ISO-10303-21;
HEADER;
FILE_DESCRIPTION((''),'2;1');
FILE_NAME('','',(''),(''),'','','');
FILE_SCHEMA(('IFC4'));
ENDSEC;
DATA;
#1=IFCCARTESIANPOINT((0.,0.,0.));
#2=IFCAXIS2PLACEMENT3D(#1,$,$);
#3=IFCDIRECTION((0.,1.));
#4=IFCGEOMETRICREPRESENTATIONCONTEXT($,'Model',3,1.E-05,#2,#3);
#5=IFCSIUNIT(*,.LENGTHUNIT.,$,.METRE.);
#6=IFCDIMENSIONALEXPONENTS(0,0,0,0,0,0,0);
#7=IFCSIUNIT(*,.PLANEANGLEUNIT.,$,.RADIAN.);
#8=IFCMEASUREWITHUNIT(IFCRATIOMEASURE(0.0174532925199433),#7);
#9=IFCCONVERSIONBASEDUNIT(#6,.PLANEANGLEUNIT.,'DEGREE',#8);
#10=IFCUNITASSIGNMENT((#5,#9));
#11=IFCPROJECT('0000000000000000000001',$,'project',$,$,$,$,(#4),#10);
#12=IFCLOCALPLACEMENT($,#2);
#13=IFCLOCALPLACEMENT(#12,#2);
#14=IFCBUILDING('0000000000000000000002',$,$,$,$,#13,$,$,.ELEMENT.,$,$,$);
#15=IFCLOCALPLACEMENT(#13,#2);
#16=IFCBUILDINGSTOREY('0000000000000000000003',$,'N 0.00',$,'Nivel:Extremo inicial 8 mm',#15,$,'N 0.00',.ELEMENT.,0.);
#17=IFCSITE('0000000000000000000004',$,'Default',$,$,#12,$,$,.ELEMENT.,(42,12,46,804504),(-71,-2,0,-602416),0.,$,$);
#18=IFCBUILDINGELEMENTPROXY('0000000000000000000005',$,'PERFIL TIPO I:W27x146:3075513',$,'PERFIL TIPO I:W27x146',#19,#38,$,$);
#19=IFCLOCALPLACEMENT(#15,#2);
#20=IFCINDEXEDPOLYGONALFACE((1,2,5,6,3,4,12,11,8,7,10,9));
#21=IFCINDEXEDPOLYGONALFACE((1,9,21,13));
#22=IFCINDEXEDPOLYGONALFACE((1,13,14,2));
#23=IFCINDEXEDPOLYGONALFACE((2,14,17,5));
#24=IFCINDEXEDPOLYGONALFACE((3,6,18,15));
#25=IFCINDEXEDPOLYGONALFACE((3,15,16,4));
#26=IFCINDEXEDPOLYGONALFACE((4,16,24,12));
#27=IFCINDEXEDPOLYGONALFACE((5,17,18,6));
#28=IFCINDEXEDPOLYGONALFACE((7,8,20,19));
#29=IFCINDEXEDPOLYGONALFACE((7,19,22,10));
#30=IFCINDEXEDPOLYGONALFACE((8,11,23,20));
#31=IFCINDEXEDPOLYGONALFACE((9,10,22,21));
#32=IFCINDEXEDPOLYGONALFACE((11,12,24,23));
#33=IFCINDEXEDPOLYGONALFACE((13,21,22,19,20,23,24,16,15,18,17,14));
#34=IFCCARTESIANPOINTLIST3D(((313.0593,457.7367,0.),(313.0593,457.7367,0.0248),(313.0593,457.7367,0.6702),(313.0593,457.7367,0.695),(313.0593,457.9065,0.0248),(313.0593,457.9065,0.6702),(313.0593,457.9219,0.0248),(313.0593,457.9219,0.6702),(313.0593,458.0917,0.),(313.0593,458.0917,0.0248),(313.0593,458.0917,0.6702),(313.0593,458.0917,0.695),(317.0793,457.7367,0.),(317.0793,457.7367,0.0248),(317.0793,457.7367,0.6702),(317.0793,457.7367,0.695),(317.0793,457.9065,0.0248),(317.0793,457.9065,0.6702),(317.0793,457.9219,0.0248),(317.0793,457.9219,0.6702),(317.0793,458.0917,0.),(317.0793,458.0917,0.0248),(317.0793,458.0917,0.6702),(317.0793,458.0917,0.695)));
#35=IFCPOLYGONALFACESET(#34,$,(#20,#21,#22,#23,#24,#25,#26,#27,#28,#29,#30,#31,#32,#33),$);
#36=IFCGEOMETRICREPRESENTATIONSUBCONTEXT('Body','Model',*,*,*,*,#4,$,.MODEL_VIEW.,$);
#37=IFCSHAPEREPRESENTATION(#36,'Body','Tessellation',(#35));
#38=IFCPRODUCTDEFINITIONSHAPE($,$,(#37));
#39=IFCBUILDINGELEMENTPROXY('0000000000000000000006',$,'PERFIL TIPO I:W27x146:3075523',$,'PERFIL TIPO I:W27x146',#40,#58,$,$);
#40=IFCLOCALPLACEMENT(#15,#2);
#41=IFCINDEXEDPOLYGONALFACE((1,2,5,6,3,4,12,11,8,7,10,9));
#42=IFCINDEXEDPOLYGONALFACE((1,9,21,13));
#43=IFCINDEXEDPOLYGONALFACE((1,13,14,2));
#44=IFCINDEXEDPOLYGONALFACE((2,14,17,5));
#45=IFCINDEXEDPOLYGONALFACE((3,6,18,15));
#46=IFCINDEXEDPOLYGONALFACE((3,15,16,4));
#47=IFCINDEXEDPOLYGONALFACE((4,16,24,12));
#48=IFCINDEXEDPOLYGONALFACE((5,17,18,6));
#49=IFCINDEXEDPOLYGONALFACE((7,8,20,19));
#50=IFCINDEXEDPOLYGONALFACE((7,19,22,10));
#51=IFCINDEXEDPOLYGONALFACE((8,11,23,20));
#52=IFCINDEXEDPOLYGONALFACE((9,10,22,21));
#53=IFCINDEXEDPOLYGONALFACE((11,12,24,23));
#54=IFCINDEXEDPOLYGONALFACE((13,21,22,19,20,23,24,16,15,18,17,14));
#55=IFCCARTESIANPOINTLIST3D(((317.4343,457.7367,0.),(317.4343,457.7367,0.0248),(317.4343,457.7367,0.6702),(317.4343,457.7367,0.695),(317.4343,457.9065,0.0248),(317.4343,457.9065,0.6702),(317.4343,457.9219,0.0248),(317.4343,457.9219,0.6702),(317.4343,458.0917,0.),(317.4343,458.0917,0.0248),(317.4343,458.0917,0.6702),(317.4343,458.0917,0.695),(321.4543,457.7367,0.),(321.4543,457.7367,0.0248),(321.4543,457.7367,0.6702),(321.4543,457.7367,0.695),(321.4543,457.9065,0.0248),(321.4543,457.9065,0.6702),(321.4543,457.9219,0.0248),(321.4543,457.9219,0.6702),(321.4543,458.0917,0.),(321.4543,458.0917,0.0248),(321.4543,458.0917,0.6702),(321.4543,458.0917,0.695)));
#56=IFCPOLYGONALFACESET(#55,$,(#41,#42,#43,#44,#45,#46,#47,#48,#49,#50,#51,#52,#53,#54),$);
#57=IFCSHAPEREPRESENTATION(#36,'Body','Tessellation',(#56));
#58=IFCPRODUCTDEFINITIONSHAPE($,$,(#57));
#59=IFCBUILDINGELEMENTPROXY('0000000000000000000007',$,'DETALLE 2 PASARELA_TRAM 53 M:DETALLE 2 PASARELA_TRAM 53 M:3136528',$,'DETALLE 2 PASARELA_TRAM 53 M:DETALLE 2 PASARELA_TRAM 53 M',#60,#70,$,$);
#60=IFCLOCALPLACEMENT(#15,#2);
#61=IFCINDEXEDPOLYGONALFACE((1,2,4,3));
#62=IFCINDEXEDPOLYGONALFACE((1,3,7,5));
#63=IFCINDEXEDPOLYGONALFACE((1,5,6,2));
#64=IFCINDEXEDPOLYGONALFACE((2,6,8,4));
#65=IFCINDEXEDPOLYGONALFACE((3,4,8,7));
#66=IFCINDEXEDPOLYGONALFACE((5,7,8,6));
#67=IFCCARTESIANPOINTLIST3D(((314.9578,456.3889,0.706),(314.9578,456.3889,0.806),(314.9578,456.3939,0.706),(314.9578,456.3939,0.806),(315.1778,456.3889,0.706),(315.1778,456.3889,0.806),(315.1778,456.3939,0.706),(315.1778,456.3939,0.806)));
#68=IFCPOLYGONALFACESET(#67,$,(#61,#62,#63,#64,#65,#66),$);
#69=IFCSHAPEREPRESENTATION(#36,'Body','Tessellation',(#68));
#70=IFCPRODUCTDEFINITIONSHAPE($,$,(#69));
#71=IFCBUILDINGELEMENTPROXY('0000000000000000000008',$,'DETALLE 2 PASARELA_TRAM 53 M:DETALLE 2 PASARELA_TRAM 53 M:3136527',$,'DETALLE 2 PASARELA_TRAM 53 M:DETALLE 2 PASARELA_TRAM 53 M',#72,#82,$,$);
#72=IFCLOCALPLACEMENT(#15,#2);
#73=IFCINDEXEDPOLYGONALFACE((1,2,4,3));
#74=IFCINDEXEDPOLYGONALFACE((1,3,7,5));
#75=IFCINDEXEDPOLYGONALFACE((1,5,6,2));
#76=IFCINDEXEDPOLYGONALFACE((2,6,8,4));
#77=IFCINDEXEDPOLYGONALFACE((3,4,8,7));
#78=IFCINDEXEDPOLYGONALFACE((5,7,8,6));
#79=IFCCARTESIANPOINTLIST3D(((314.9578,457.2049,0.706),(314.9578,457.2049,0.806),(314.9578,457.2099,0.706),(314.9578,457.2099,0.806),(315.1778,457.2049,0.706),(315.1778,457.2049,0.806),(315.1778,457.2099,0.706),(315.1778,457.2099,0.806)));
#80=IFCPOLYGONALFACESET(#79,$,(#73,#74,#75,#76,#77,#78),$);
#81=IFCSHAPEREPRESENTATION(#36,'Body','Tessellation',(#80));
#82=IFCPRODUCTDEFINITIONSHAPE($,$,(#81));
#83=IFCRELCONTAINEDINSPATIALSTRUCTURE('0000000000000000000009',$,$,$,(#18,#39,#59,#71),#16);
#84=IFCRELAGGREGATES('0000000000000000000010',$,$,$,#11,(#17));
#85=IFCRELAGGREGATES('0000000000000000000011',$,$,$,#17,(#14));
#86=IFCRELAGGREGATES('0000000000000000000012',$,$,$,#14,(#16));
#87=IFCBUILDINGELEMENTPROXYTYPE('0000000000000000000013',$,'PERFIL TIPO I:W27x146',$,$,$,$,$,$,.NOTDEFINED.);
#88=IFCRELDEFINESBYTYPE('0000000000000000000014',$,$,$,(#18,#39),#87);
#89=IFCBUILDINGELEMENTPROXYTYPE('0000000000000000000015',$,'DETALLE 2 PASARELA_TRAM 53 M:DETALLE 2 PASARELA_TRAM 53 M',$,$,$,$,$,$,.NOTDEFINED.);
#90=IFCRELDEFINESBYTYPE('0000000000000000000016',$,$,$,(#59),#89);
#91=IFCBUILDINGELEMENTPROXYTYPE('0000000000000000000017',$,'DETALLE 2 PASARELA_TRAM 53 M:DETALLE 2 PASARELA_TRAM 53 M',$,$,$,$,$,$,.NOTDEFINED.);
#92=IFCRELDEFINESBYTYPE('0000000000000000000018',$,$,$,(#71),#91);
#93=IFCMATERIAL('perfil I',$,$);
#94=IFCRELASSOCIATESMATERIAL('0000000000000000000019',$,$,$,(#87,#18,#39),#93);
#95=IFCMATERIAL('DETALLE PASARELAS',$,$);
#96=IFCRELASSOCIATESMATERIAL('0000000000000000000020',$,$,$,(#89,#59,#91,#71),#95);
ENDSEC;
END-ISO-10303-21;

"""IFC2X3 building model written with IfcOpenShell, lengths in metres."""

from ifc_helpers import new_model, entity, si_unit, converted_unit, direction, frame, frame_2d, origin, place, context, subcontext, project, spatial, polyline, rectangle, outline, extrude, source, transform, mapped, material, type_object, type_shapes, element, save


model = new_model("IFC2X3")

# Units and contexts
model_context = context("Model", 3, precision=1e-05, world=origin(), true_north=direction((0.0, 1.0)))
body_context = subcontext(model_context, "Body", "Model", "MODEL_VIEW")
ifc_project = project(units=[si_unit("LENGTHUNIT", "METRE"), converted_unit("PLANEANGLEUNIT", "DEGREE", entity("IfcRatioMeasure", 0.0174532925199433), si_unit("PLANEANGLEUNIT", "RADIAN"), dimensions=[0, 0, 0, 0, 0, 0, 0])], contexts=[model_context])

# Site, building, storey
site_placement = place(None, origin())
site = spatial("IfcSite", under=ifc_project, at=site_placement, Name="Default", CompositionType="ELEMENT", RefLatitude=(42, 12, 46, 804504), RefLongitude=(-71, -2, 0, -602416), RefElevation=0.0)
building_placement = place(site_placement, origin())
building = spatial("IfcBuilding", under=site, at=building_placement, CompositionType="ELEMENT")
storey_placement = place(building_placement, origin())
storey = spatial("IfcBuildingStorey", under=building, at=storey_placement, Name="N 0.00", ObjectType="Nivel:Extremo inicial 8 mm", LongName="N 0.00", CompositionType="ELEMENT", Elevation=0.0)

# Building element proxies
ifc_material_1 = material(Name="perfil I")
building_element_proxy_type_1 = type_object("IfcBuildingElementProxyType", Name="PERFIL TIPO I:W27x146", PredefinedType="NOTDEFINED", material=ifc_material_1)
shared_shape_1 = source(origin(), body_context, "Body", "SweptSolid", [
    extrude(outline(polyline([(0.3227, -0.1775), (0.3475, -0.1775), (0.3475, 0.1775), (0.3227, 0.1775), (0.3227, 0.0077), (-0.3227, 0.0077), (-0.3227, 0.1775), (-0.3475, 0.1775), (-0.3475, -0.1775), (-0.3227, -0.1775), (-0.3227, -0.0077), (0.3227, -0.0077), (0.3227, -0.1775)])), frame((0.0, 0.0, 0.3475), z_axis=(1.0, 0.0, 0.0), x_axis=(0.0, 0.0, 1.0)), (0.0, 0.0, 1.0), 4.02),
])
type_shapes(building_element_proxy_type_1, [shared_shape_1])
for number, where, name in (
    (1, (313.0593, 457.9142, 0.0), "PERFIL TIPO I:W27x146:3075513"),
    (2, (317.4343, 457.9142, 0.0), "PERFIL TIPO I:W27x146:3075523"),
):
    element("IfcBuildingElementProxy", number, at=place(storey_placement, frame(where)), inside=storey, type_object=building_element_proxy_type_1, material=ifc_material_1, Name=name, ObjectType="PERFIL TIPO I:W27x146", context=body_context, shape_type="MappedRepresentation", body=[
        mapped(shared_shape_1, transform((0.0, 0.0, 0.0), scale=1.0)),
    ])
ifc_material_2 = material(Name="DETALLE PASARELAS")
building_element_proxy_type_2 = type_object("IfcBuildingElementProxyType", Name="DETALLE 2 PASARELA_TRAM 53 M:DETALLE 2 PASARELA_TRAM 53 M", PredefinedType="NOTDEFINED", material=ifc_material_2)
shared_shape_2 = source(origin(), body_context, "Body", "SweptSolid", [
    extrude(rectangle(XDim=0.22, YDim=0.005, at=frame_2d((0.0, 0.0), x_axis=(1.0, 0.0))), frame((0.11, 0.0475, 0.0), z_axis=(0.0, 0.0, 1.0), x_axis=(-1.0, 0.0, 0.0)), (0.0, 0.0, 1.0), 0.1),
])
type_shapes(building_element_proxy_type_2, [shared_shape_2])
proxy_1_placement = place(storey_placement, frame((314.9578, 456.3439, 0.706)))
element("IfcBuildingElementProxy", 3, at=proxy_1_placement, inside=storey, type_object=building_element_proxy_type_2, material=ifc_material_2, Name="DETALLE 2 PASARELA_TRAM 53 M:DETALLE 2 PASARELA_TRAM 53 M:3136528", ObjectType="DETALLE 2 PASARELA_TRAM 53 M:DETALLE 2 PASARELA_TRAM 53 M", context=body_context, shape_type="MappedRepresentation", body=[
    mapped(shared_shape_2, transform((0.0, 0.0, 0.0), scale=1.0)),
])
building_element_proxy_type_3 = type_object("IfcBuildingElementProxyType", Name="DETALLE 2 PASARELA_TRAM 53 M:DETALLE 2 PASARELA_TRAM 53 M", PredefinedType="NOTDEFINED", material=ifc_material_2)
shared_shape_3 = source(origin(), body_context, "Body", "SweptSolid", [
    extrude(rectangle(XDim=0.005, YDim=0.22, at=frame_2d((0.0, 0.0), x_axis=(1.0, 0.0))), frame((0.11, -0.0475, 0.0), z_axis=(0.0, 0.0, 1.0), x_axis=(0.0, 1.0, 0.0)), (0.0, 0.0, 1.0), 0.1),
])
type_shapes(building_element_proxy_type_3, [shared_shape_3])
proxy_2_placement = place(storey_placement, frame((314.9578, 457.2549, 0.706)))
element("IfcBuildingElementProxy", 4, at=proxy_2_placement, inside=storey, type_object=building_element_proxy_type_3, material=ifc_material_2, Name="DETALLE 2 PASARELA_TRAM 53 M:DETALLE 2 PASARELA_TRAM 53 M:3136527", ObjectType="DETALLE 2 PASARELA_TRAM 53 M:DETALLE 2 PASARELA_TRAM 53 M", context=body_context, shape_type="MappedRepresentation", body=[
    mapped(shared_shape_3, transform((0.0, 0.0, 0.0), scale=1.0)),
])

save(model, "model.ifc")
